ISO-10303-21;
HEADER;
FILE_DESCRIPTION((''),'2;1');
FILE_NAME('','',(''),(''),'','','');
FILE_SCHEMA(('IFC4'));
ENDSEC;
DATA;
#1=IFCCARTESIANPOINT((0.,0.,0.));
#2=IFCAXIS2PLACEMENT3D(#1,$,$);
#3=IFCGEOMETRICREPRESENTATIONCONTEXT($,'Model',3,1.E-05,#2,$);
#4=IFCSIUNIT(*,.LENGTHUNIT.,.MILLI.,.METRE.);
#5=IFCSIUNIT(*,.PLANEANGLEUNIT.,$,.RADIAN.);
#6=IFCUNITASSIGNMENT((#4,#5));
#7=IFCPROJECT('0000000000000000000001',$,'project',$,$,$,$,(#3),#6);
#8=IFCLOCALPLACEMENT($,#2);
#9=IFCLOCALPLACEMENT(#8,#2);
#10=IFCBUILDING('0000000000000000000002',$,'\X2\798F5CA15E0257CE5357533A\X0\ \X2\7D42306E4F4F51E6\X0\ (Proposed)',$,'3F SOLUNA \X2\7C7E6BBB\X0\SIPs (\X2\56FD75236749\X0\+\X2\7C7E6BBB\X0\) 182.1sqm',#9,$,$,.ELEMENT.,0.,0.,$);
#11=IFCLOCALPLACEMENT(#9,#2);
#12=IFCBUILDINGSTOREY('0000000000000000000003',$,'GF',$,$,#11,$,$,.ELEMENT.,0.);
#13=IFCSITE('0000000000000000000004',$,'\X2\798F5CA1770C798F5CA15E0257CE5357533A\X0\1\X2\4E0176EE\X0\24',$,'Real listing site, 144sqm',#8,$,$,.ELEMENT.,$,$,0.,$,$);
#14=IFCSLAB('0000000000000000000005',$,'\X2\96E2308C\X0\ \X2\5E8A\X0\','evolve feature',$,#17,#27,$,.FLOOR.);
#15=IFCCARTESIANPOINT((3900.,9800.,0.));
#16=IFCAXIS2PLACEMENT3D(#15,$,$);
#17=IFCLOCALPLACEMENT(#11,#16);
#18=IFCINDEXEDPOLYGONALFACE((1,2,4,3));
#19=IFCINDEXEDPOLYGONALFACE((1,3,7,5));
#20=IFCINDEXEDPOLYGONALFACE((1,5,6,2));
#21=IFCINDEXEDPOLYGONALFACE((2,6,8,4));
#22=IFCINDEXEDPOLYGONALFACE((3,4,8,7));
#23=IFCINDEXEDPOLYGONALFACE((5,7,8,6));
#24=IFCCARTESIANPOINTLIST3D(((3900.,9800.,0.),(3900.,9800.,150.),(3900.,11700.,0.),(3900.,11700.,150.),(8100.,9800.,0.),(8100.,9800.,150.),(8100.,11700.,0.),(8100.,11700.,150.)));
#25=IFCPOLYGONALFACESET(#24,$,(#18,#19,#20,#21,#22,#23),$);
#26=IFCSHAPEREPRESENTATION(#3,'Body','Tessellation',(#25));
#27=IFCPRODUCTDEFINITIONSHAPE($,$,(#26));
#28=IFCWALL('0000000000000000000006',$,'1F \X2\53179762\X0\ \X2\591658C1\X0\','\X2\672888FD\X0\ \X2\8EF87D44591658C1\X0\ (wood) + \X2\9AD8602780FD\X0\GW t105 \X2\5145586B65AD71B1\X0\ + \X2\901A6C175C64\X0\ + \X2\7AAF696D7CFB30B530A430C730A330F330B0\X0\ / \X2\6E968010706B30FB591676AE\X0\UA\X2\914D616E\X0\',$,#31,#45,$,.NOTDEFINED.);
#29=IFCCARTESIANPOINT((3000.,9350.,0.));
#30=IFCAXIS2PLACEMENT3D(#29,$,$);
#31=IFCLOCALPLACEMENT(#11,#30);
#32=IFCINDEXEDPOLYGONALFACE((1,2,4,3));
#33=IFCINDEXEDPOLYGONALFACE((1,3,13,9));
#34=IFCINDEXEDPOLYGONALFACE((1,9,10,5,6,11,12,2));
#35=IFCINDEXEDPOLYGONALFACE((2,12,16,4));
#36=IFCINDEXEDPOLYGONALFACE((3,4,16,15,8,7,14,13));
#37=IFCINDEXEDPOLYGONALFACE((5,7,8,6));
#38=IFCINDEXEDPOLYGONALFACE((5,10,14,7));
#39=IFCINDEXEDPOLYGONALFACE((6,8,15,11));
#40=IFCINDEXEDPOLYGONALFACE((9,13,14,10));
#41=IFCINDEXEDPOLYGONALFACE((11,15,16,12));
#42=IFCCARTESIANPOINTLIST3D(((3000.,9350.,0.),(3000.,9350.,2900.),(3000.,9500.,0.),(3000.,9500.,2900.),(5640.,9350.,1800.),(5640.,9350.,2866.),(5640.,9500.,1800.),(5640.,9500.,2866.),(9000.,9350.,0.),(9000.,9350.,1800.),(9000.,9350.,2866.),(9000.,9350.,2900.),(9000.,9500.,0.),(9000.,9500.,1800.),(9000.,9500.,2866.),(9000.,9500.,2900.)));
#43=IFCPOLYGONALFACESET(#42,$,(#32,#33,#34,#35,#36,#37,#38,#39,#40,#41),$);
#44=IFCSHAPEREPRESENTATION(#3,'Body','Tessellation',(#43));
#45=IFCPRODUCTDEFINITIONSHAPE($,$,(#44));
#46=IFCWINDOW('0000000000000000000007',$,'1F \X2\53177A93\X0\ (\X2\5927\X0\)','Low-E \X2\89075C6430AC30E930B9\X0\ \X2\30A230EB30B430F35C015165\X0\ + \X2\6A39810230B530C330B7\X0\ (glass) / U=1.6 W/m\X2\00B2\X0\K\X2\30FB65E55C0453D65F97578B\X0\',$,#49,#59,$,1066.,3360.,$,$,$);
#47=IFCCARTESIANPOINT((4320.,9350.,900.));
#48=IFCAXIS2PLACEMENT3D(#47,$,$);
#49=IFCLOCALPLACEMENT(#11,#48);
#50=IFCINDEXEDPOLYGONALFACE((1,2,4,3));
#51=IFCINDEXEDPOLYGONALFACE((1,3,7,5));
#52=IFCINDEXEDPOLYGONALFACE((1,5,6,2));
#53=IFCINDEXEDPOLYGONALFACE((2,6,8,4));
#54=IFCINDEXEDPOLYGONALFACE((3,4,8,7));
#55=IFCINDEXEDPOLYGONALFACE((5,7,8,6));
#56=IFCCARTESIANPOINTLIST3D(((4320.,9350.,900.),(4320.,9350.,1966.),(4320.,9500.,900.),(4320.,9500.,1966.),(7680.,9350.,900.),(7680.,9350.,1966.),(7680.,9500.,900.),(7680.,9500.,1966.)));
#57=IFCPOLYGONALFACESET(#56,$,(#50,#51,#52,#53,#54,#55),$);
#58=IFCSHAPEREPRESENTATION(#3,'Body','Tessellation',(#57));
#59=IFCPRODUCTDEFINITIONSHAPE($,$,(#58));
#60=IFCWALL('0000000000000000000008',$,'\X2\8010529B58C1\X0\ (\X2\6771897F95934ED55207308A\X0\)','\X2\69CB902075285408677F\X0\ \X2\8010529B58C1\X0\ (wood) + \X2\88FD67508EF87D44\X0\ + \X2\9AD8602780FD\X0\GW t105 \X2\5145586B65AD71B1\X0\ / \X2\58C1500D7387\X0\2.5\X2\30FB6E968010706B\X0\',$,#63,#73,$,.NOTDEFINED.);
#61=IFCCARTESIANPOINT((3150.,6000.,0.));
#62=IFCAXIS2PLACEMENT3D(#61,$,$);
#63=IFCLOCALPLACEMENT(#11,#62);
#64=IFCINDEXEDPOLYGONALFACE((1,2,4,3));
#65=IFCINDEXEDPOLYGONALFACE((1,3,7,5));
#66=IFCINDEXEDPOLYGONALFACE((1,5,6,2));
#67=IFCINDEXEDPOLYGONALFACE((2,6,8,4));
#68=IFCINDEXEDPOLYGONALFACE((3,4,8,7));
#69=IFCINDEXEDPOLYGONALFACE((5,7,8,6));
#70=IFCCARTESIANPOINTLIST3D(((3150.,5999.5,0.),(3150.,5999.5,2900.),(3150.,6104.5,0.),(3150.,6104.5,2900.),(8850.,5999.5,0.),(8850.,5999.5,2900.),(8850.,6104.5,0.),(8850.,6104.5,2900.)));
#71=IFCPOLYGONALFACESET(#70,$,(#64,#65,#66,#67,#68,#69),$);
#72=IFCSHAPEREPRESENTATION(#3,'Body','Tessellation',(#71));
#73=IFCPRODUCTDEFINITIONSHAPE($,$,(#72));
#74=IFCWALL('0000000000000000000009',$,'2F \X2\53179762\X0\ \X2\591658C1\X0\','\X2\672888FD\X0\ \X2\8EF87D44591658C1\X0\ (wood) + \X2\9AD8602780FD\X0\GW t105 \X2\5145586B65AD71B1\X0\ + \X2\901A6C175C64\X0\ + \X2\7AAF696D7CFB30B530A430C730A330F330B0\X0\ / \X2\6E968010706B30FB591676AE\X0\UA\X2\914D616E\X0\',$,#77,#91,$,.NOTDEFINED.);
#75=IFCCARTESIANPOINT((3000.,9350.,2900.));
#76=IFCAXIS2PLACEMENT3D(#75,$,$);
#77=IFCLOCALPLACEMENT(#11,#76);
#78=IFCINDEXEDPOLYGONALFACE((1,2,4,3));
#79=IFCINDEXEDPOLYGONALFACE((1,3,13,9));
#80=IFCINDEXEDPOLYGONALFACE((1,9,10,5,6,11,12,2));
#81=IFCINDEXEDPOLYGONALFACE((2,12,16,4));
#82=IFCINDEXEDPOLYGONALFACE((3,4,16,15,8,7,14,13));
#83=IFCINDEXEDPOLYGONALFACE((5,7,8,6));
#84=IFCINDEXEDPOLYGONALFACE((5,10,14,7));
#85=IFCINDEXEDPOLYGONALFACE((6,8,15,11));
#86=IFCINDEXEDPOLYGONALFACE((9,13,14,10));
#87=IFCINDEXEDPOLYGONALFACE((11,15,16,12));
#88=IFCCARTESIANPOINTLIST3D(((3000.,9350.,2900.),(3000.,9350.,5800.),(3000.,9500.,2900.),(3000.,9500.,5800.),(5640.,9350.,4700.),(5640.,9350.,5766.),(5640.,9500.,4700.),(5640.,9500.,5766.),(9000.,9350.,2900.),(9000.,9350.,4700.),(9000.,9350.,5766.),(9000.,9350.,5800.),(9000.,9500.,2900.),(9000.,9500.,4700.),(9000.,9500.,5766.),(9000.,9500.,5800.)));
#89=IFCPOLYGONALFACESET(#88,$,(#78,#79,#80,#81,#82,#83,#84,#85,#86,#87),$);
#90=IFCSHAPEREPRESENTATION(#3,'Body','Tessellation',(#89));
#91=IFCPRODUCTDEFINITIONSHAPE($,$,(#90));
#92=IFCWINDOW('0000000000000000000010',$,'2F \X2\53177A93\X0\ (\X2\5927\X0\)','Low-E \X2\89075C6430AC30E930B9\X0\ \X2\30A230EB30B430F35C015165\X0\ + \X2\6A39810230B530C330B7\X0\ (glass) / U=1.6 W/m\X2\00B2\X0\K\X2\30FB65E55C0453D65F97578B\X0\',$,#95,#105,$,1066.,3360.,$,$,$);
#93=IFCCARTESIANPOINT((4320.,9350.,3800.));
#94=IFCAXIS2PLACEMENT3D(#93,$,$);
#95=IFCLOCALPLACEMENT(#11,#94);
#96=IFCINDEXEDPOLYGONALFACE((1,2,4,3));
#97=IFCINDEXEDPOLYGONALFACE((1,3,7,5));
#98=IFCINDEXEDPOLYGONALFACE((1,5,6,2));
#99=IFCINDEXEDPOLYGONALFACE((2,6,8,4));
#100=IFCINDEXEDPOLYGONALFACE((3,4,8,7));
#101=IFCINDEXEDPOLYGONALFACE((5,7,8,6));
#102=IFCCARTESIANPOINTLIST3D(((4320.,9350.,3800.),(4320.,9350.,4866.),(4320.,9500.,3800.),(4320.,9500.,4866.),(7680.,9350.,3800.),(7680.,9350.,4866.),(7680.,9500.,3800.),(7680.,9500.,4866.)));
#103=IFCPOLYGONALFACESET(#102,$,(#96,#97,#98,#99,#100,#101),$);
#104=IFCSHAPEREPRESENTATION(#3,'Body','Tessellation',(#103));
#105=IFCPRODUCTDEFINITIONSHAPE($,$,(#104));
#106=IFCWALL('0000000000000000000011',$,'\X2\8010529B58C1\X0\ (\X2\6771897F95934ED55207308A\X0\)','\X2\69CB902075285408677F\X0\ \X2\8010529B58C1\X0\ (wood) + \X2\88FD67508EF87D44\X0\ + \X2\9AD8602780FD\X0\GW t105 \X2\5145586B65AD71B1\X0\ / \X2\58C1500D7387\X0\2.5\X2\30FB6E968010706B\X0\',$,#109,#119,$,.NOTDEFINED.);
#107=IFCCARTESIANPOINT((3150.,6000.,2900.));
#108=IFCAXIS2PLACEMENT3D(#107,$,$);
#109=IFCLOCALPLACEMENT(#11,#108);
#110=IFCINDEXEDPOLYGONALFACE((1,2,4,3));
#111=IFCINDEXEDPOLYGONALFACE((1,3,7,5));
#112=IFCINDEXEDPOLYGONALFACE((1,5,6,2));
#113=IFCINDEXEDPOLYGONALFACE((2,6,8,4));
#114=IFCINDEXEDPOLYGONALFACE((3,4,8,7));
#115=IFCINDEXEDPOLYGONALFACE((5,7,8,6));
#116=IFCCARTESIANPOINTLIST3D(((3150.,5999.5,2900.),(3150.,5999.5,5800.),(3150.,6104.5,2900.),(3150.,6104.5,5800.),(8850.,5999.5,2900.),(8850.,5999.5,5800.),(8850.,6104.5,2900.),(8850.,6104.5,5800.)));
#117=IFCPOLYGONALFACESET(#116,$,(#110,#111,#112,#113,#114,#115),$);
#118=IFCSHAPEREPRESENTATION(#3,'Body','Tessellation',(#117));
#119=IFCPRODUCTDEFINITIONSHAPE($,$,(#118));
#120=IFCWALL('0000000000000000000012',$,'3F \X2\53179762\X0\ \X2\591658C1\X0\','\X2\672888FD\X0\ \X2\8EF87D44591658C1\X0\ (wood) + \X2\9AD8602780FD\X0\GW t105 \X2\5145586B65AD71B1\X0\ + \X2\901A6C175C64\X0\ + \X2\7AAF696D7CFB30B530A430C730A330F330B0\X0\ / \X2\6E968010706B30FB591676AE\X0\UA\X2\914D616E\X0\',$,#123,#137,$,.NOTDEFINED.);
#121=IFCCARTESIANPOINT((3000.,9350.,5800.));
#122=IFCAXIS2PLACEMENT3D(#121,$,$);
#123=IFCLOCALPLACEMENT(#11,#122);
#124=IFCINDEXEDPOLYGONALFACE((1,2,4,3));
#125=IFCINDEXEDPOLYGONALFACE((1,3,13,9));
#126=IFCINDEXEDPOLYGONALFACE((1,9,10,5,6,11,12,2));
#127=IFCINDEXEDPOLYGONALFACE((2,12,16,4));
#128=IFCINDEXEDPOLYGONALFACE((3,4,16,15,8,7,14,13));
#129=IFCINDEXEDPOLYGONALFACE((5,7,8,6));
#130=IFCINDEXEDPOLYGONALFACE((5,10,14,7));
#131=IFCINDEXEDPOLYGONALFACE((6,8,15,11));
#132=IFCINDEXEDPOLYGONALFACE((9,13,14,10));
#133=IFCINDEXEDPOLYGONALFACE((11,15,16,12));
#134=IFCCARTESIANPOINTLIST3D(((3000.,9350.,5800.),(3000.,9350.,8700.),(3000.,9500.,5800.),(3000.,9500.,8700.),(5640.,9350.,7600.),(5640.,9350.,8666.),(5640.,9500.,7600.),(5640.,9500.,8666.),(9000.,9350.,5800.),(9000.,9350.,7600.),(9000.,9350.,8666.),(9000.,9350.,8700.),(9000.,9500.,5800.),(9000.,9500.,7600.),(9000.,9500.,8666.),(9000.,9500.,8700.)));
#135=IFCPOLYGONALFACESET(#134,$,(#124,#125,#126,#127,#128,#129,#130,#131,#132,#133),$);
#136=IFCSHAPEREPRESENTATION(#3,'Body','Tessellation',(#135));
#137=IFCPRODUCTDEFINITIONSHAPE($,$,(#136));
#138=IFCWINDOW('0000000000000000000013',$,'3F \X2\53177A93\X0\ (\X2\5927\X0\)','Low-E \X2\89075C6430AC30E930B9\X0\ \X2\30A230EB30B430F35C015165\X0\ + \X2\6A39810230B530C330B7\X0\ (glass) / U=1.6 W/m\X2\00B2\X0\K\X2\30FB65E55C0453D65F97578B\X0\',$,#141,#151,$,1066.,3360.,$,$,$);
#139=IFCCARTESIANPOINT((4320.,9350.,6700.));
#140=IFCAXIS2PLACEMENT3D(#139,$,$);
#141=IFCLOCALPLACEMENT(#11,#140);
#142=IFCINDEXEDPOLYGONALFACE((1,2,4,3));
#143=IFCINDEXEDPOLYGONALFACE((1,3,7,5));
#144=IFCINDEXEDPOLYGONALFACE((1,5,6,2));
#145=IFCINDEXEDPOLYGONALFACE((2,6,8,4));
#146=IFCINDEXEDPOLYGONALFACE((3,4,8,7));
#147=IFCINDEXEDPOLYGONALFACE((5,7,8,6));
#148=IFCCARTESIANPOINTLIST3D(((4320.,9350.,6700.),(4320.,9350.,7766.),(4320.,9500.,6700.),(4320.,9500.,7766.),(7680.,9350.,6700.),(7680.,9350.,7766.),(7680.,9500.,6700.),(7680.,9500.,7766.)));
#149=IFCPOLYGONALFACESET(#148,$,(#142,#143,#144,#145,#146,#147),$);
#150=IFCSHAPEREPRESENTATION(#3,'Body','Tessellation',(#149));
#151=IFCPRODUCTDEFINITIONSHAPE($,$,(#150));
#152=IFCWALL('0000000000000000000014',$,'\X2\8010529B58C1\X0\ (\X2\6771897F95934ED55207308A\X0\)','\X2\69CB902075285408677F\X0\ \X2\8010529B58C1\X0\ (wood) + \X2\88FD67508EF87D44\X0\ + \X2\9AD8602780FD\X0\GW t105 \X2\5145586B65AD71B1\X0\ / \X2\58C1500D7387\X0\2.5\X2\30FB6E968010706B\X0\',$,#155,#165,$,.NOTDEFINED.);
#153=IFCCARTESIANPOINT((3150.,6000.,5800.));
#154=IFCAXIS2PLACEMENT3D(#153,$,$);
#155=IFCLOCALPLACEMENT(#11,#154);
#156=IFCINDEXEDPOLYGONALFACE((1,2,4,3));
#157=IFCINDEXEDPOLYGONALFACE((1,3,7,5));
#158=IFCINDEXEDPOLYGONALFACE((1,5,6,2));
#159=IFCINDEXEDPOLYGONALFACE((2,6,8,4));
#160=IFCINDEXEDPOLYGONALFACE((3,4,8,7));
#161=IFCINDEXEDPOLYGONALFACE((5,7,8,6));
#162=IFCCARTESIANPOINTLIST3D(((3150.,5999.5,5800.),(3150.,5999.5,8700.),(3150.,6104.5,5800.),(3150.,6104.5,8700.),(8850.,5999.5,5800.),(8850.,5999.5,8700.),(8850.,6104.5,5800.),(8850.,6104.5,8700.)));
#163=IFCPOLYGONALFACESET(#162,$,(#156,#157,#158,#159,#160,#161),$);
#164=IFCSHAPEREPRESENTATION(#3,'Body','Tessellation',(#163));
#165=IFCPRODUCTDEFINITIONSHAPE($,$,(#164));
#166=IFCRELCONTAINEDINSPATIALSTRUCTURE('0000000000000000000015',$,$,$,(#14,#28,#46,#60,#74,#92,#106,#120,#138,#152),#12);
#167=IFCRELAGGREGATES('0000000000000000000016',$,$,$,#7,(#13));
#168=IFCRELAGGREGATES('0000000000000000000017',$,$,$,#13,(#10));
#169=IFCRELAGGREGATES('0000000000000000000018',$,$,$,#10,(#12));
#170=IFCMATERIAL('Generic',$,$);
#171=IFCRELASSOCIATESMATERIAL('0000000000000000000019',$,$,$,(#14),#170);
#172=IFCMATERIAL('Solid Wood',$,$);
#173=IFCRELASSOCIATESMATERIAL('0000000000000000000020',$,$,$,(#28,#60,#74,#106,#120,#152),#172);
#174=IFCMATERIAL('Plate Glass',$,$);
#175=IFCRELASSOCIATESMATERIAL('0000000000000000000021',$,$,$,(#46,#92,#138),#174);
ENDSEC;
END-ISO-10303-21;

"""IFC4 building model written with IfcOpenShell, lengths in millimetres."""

from ifc_helpers import new_model, si_unit, frame, frame_2d, origin, place, context, project, spatial, rectangle, extrude, material, element, fill, save


model = new_model("IFC4")

# Units and contexts
model_context = context("Model", 3, precision=1e-05, world=origin())
ifc_project = project(units=[si_unit("LENGTHUNIT", "METRE", prefix="MILLI"), si_unit("PLANEANGLEUNIT", "RADIAN")], contexts=[model_context])

# Site, building, storey
site_placement = place(None, origin())
site = spatial("IfcSite", under=ifc_project, at=site_placement, Name="福岡県福岡市城南区1丁目24", ObjectType="Real listing site, 144sqm", CompositionType="ELEMENT", RefElevation=0.0)
building_placement = place(site_placement, origin())
building = spatial("IfcBuilding", under=site, at=building_placement, Name="福岡市城南区 終の住処 (Proposed)", ObjectType="3F SOLUNA 籾殻SIPs (国産杉+籾殻) 182.1sqm", CompositionType="ELEMENT", ElevationOfRefHeight=0.0, ElevationOfTerrain=0.0)
storey_placement = place(building_placement, origin())
storey = spatial("IfcBuildingStorey", under=building, at=storey_placement, Name="GF", CompositionType="ELEMENT", Elevation=0.0)

# Slab
ifc_material_1 = material(Name="Generic")
slab_placement = place(storey_placement, frame((3900.0, 9800.0, 0.0)))
element("IfcSlab", 1, at=slab_placement, inside=storey, material=ifc_material_1, Name="離れ 床", Description="evolve feature", PredefinedType="FLOOR", context=model_context, shape_type="SweptSolid", body=[
    extrude(rectangle(XDim=4200.0, YDim=1900.0, at=frame_2d((2100.0, 950.0))), frame((3900.0, 9800.0, 0.0)), (0.0, 0.0, 1.0), 150.0),
])

# Wall, opening, window
ifc_material_2 = material(Name="Solid Wood")
wall_1_placement = place(storey_placement, frame((3000.0, 9350.0, 0.0)))
wall_1 = element("IfcWall", 2, at=wall_1_placement, inside=storey, material=ifc_material_2, Name="1F 北面 外壁", Description="木製 軸組外壁 (wood) + 高性能GW t105 充填断熱 + 通気層 + 窯業系サイディング / 準耐火・外皮UA配慮", PredefinedType="NOTDEFINED", context=model_context, shape_type="SweptSolid", body=[
    extrude(rectangle(XDim=6000.0, YDim=150.0, at=frame_2d((3000.0, 75.0))), frame((3000.0, 9350.0, 0.0)), (0.0, 0.0, 1.0), 2900.0),
])
opening_1_placement = place(storey_placement, frame((4320.0, 9350.0, 900.0)))
opening_1 = element("IfcOpeningElement", 3, at=opening_1_placement, cuts=wall_1, PredefinedType="NOTDEFINED", context=model_context, shape_type="SweptSolid", body=[
    extrude(rectangle(XDim=3360.0, YDim=150.0, at=frame_2d((1680.0, 75.0))), frame((4320.0, 9350.0, 900.0)), (0.0, 0.0, 1.0), 1066.0),
])
ifc_material_3 = material(Name="Plate Glass")
window_1_placement = place(storey_placement, frame((4320.0, 9350.0, 900.0)))
window_1 = element("IfcWindow", 4, at=window_1_placement, inside=storey, material=ifc_material_3, Name="1F 北窓 (大)", Description="Low-E 複層ガラス アルゴン封入 + 樹脂サッシ (glass) / U=1.6 W/m²K・日射取得型", OverallHeight=1066.0, OverallWidth=3360.0, context=model_context, shape_type="SweptSolid", body=[
    extrude(rectangle(XDim=3360.0, YDim=150.0, at=frame_2d((1680.0, 75.0))), frame((4320.0, 9350.0, 900.0)), (0.0, 0.0, 1.0), 1066.0),
])
fill(opening_1, window_1)

# Wall
wall_2_placement = place(storey_placement, frame((3150.0, 6000.0, 0.0)))
element("IfcWall", 5, at=wall_2_placement, inside=storey, material=ifc_material_2, Name="耐力壁 (東西間仕切り)", Description="構造用合板 耐力壁 (wood) + 製材軸組 + 高性能GW t105 充填断熱 / 壁倍率2.5・準耐火", PredefinedType="NOTDEFINED", context=model_context, shape_type="SweptSolid", body=[
    extrude(rectangle(XDim=5700.0, YDim=105.0, at=frame_2d((2850.0, 52.0))), frame((3150.0, 6000.0, 0.0)), (0.0, 0.0, 1.0), 2900.0),
])

# Wall, opening, window
wall_3_placement = place(storey_placement, frame((3000.0, 9350.0, 2900.0)))
wall_3 = element("IfcWall", 6, at=wall_3_placement, inside=storey, material=ifc_material_2, Name="2F 北面 外壁", Description="木製 軸組外壁 (wood) + 高性能GW t105 充填断熱 + 通気層 + 窯業系サイディング / 準耐火・外皮UA配慮", PredefinedType="NOTDEFINED", context=model_context, shape_type="SweptSolid", body=[
    extrude(rectangle(XDim=6000.0, YDim=150.0, at=frame_2d((3000.0, 75.0))), frame((3000.0, 9350.0, 2900.0)), (0.0, 0.0, 1.0), 2900.0),
])
opening_2_placement = place(storey_placement, frame((4320.0, 9350.0, 3800.0)))
opening_2 = element("IfcOpeningElement", 7, at=opening_2_placement, cuts=wall_3, PredefinedType="NOTDEFINED", context=model_context, shape_type="SweptSolid", body=[
    extrude(rectangle(XDim=3360.0, YDim=150.0, at=frame_2d((1680.0, 75.0))), frame((4320.0, 9350.0, 3800.0)), (0.0, 0.0, 1.0), 1066.0),
])
window_2_placement = place(storey_placement, frame((4320.0, 9350.0, 3800.0)))
window_2 = element("IfcWindow", 8, at=window_2_placement, inside=storey, material=ifc_material_3, Name="2F 北窓 (大)", Description="Low-E 複層ガラス アルゴン封入 + 樹脂サッシ (glass) / U=1.6 W/m²K・日射取得型", OverallHeight=1066.0, OverallWidth=3360.0, context=model_context, shape_type="SweptSolid", body=[
    extrude(rectangle(XDim=3360.0, YDim=150.0, at=frame_2d((1680.0, 75.0))), frame((4320.0, 9350.0, 3800.0)), (0.0, 0.0, 1.0), 1066.0),
])
fill(opening_2, window_2)

# Wall
wall_4_placement = place(storey_placement, frame((3150.0, 6000.0, 2900.0)))
element("IfcWall", 9, at=wall_4_placement, inside=storey, material=ifc_material_2, Name="耐力壁 (東西間仕切り)", Description="構造用合板 耐力壁 (wood) + 製材軸組 + 高性能GW t105 充填断熱 / 壁倍率2.5・準耐火", PredefinedType="NOTDEFINED", context=model_context, shape_type="SweptSolid", body=[
    extrude(rectangle(XDim=5700.0, YDim=105.0, at=frame_2d((2850.0, 52.0))), frame((3150.0, 6000.0, 2900.0)), (0.0, 0.0, 1.0), 2900.0),
])

# Wall, opening, window
wall_5_placement = place(storey_placement, frame((3000.0, 9350.0, 5800.0)))
wall_5 = element("IfcWall", 10, at=wall_5_placement, inside=storey, material=ifc_material_2, Name="3F 北面 外壁", Description="木製 軸組外壁 (wood) + 高性能GW t105 充填断熱 + 通気層 + 窯業系サイディング / 準耐火・外皮UA配慮", PredefinedType="NOTDEFINED", context=model_context, shape_type="SweptSolid", body=[
    extrude(rectangle(XDim=6000.0, YDim=150.0, at=frame_2d((3000.0, 75.0))), frame((3000.0, 9350.0, 5800.0)), (0.0, 0.0, 1.0), 2900.0),
])
opening_3_placement = place(storey_placement, frame((4320.0, 9350.0, 6700.0)))
opening_3 = element("IfcOpeningElement", 11, at=opening_3_placement, cuts=wall_5, PredefinedType="NOTDEFINED", context=model_context, shape_type="SweptSolid", body=[
    extrude(rectangle(XDim=3360.0, YDim=150.0, at=frame_2d((1680.0, 75.0))), frame((4320.0, 9350.0, 6700.0)), (0.0, 0.0, 1.0), 1066.0),
])
window_3_placement = place(storey_placement, frame((4320.0, 9350.0, 6700.0)))
window_3 = element("IfcWindow", 12, at=window_3_placement, inside=storey, material=ifc_material_3, Name="3F 北窓 (大)", Description="Low-E 複層ガラス アルゴン封入 + 樹脂サッシ (glass) / U=1.6 W/m²K・日射取得型", OverallHeight=1066.0, OverallWidth=3360.0, context=model_context, shape_type="SweptSolid", body=[
    extrude(rectangle(XDim=3360.0, YDim=150.0, at=frame_2d((1680.0, 75.0))), frame((4320.0, 9350.0, 6700.0)), (0.0, 0.0, 1.0), 1066.0),
])
fill(opening_3, window_3)

# Wall
wall_6_placement = place(storey_placement, frame((3150.0, 6000.0, 5800.0)))
element("IfcWall", 13, at=wall_6_placement, inside=storey, material=ifc_material_2, Name="耐力壁 (東西間仕切り)", Description="構造用合板 耐力壁 (wood) + 製材軸組 + 高性能GW t105 充填断熱 / 壁倍率2.5・準耐火", PredefinedType="NOTDEFINED", context=model_context, shape_type="SweptSolid", body=[
    extrude(rectangle(XDim=5700.0, YDim=105.0, at=frame_2d((2850.0, 52.0))), frame((3150.0, 6000.0, 5800.0)), (0.0, 0.0, 1.0), 2900.0),
])

save(model, "model.ifc")
